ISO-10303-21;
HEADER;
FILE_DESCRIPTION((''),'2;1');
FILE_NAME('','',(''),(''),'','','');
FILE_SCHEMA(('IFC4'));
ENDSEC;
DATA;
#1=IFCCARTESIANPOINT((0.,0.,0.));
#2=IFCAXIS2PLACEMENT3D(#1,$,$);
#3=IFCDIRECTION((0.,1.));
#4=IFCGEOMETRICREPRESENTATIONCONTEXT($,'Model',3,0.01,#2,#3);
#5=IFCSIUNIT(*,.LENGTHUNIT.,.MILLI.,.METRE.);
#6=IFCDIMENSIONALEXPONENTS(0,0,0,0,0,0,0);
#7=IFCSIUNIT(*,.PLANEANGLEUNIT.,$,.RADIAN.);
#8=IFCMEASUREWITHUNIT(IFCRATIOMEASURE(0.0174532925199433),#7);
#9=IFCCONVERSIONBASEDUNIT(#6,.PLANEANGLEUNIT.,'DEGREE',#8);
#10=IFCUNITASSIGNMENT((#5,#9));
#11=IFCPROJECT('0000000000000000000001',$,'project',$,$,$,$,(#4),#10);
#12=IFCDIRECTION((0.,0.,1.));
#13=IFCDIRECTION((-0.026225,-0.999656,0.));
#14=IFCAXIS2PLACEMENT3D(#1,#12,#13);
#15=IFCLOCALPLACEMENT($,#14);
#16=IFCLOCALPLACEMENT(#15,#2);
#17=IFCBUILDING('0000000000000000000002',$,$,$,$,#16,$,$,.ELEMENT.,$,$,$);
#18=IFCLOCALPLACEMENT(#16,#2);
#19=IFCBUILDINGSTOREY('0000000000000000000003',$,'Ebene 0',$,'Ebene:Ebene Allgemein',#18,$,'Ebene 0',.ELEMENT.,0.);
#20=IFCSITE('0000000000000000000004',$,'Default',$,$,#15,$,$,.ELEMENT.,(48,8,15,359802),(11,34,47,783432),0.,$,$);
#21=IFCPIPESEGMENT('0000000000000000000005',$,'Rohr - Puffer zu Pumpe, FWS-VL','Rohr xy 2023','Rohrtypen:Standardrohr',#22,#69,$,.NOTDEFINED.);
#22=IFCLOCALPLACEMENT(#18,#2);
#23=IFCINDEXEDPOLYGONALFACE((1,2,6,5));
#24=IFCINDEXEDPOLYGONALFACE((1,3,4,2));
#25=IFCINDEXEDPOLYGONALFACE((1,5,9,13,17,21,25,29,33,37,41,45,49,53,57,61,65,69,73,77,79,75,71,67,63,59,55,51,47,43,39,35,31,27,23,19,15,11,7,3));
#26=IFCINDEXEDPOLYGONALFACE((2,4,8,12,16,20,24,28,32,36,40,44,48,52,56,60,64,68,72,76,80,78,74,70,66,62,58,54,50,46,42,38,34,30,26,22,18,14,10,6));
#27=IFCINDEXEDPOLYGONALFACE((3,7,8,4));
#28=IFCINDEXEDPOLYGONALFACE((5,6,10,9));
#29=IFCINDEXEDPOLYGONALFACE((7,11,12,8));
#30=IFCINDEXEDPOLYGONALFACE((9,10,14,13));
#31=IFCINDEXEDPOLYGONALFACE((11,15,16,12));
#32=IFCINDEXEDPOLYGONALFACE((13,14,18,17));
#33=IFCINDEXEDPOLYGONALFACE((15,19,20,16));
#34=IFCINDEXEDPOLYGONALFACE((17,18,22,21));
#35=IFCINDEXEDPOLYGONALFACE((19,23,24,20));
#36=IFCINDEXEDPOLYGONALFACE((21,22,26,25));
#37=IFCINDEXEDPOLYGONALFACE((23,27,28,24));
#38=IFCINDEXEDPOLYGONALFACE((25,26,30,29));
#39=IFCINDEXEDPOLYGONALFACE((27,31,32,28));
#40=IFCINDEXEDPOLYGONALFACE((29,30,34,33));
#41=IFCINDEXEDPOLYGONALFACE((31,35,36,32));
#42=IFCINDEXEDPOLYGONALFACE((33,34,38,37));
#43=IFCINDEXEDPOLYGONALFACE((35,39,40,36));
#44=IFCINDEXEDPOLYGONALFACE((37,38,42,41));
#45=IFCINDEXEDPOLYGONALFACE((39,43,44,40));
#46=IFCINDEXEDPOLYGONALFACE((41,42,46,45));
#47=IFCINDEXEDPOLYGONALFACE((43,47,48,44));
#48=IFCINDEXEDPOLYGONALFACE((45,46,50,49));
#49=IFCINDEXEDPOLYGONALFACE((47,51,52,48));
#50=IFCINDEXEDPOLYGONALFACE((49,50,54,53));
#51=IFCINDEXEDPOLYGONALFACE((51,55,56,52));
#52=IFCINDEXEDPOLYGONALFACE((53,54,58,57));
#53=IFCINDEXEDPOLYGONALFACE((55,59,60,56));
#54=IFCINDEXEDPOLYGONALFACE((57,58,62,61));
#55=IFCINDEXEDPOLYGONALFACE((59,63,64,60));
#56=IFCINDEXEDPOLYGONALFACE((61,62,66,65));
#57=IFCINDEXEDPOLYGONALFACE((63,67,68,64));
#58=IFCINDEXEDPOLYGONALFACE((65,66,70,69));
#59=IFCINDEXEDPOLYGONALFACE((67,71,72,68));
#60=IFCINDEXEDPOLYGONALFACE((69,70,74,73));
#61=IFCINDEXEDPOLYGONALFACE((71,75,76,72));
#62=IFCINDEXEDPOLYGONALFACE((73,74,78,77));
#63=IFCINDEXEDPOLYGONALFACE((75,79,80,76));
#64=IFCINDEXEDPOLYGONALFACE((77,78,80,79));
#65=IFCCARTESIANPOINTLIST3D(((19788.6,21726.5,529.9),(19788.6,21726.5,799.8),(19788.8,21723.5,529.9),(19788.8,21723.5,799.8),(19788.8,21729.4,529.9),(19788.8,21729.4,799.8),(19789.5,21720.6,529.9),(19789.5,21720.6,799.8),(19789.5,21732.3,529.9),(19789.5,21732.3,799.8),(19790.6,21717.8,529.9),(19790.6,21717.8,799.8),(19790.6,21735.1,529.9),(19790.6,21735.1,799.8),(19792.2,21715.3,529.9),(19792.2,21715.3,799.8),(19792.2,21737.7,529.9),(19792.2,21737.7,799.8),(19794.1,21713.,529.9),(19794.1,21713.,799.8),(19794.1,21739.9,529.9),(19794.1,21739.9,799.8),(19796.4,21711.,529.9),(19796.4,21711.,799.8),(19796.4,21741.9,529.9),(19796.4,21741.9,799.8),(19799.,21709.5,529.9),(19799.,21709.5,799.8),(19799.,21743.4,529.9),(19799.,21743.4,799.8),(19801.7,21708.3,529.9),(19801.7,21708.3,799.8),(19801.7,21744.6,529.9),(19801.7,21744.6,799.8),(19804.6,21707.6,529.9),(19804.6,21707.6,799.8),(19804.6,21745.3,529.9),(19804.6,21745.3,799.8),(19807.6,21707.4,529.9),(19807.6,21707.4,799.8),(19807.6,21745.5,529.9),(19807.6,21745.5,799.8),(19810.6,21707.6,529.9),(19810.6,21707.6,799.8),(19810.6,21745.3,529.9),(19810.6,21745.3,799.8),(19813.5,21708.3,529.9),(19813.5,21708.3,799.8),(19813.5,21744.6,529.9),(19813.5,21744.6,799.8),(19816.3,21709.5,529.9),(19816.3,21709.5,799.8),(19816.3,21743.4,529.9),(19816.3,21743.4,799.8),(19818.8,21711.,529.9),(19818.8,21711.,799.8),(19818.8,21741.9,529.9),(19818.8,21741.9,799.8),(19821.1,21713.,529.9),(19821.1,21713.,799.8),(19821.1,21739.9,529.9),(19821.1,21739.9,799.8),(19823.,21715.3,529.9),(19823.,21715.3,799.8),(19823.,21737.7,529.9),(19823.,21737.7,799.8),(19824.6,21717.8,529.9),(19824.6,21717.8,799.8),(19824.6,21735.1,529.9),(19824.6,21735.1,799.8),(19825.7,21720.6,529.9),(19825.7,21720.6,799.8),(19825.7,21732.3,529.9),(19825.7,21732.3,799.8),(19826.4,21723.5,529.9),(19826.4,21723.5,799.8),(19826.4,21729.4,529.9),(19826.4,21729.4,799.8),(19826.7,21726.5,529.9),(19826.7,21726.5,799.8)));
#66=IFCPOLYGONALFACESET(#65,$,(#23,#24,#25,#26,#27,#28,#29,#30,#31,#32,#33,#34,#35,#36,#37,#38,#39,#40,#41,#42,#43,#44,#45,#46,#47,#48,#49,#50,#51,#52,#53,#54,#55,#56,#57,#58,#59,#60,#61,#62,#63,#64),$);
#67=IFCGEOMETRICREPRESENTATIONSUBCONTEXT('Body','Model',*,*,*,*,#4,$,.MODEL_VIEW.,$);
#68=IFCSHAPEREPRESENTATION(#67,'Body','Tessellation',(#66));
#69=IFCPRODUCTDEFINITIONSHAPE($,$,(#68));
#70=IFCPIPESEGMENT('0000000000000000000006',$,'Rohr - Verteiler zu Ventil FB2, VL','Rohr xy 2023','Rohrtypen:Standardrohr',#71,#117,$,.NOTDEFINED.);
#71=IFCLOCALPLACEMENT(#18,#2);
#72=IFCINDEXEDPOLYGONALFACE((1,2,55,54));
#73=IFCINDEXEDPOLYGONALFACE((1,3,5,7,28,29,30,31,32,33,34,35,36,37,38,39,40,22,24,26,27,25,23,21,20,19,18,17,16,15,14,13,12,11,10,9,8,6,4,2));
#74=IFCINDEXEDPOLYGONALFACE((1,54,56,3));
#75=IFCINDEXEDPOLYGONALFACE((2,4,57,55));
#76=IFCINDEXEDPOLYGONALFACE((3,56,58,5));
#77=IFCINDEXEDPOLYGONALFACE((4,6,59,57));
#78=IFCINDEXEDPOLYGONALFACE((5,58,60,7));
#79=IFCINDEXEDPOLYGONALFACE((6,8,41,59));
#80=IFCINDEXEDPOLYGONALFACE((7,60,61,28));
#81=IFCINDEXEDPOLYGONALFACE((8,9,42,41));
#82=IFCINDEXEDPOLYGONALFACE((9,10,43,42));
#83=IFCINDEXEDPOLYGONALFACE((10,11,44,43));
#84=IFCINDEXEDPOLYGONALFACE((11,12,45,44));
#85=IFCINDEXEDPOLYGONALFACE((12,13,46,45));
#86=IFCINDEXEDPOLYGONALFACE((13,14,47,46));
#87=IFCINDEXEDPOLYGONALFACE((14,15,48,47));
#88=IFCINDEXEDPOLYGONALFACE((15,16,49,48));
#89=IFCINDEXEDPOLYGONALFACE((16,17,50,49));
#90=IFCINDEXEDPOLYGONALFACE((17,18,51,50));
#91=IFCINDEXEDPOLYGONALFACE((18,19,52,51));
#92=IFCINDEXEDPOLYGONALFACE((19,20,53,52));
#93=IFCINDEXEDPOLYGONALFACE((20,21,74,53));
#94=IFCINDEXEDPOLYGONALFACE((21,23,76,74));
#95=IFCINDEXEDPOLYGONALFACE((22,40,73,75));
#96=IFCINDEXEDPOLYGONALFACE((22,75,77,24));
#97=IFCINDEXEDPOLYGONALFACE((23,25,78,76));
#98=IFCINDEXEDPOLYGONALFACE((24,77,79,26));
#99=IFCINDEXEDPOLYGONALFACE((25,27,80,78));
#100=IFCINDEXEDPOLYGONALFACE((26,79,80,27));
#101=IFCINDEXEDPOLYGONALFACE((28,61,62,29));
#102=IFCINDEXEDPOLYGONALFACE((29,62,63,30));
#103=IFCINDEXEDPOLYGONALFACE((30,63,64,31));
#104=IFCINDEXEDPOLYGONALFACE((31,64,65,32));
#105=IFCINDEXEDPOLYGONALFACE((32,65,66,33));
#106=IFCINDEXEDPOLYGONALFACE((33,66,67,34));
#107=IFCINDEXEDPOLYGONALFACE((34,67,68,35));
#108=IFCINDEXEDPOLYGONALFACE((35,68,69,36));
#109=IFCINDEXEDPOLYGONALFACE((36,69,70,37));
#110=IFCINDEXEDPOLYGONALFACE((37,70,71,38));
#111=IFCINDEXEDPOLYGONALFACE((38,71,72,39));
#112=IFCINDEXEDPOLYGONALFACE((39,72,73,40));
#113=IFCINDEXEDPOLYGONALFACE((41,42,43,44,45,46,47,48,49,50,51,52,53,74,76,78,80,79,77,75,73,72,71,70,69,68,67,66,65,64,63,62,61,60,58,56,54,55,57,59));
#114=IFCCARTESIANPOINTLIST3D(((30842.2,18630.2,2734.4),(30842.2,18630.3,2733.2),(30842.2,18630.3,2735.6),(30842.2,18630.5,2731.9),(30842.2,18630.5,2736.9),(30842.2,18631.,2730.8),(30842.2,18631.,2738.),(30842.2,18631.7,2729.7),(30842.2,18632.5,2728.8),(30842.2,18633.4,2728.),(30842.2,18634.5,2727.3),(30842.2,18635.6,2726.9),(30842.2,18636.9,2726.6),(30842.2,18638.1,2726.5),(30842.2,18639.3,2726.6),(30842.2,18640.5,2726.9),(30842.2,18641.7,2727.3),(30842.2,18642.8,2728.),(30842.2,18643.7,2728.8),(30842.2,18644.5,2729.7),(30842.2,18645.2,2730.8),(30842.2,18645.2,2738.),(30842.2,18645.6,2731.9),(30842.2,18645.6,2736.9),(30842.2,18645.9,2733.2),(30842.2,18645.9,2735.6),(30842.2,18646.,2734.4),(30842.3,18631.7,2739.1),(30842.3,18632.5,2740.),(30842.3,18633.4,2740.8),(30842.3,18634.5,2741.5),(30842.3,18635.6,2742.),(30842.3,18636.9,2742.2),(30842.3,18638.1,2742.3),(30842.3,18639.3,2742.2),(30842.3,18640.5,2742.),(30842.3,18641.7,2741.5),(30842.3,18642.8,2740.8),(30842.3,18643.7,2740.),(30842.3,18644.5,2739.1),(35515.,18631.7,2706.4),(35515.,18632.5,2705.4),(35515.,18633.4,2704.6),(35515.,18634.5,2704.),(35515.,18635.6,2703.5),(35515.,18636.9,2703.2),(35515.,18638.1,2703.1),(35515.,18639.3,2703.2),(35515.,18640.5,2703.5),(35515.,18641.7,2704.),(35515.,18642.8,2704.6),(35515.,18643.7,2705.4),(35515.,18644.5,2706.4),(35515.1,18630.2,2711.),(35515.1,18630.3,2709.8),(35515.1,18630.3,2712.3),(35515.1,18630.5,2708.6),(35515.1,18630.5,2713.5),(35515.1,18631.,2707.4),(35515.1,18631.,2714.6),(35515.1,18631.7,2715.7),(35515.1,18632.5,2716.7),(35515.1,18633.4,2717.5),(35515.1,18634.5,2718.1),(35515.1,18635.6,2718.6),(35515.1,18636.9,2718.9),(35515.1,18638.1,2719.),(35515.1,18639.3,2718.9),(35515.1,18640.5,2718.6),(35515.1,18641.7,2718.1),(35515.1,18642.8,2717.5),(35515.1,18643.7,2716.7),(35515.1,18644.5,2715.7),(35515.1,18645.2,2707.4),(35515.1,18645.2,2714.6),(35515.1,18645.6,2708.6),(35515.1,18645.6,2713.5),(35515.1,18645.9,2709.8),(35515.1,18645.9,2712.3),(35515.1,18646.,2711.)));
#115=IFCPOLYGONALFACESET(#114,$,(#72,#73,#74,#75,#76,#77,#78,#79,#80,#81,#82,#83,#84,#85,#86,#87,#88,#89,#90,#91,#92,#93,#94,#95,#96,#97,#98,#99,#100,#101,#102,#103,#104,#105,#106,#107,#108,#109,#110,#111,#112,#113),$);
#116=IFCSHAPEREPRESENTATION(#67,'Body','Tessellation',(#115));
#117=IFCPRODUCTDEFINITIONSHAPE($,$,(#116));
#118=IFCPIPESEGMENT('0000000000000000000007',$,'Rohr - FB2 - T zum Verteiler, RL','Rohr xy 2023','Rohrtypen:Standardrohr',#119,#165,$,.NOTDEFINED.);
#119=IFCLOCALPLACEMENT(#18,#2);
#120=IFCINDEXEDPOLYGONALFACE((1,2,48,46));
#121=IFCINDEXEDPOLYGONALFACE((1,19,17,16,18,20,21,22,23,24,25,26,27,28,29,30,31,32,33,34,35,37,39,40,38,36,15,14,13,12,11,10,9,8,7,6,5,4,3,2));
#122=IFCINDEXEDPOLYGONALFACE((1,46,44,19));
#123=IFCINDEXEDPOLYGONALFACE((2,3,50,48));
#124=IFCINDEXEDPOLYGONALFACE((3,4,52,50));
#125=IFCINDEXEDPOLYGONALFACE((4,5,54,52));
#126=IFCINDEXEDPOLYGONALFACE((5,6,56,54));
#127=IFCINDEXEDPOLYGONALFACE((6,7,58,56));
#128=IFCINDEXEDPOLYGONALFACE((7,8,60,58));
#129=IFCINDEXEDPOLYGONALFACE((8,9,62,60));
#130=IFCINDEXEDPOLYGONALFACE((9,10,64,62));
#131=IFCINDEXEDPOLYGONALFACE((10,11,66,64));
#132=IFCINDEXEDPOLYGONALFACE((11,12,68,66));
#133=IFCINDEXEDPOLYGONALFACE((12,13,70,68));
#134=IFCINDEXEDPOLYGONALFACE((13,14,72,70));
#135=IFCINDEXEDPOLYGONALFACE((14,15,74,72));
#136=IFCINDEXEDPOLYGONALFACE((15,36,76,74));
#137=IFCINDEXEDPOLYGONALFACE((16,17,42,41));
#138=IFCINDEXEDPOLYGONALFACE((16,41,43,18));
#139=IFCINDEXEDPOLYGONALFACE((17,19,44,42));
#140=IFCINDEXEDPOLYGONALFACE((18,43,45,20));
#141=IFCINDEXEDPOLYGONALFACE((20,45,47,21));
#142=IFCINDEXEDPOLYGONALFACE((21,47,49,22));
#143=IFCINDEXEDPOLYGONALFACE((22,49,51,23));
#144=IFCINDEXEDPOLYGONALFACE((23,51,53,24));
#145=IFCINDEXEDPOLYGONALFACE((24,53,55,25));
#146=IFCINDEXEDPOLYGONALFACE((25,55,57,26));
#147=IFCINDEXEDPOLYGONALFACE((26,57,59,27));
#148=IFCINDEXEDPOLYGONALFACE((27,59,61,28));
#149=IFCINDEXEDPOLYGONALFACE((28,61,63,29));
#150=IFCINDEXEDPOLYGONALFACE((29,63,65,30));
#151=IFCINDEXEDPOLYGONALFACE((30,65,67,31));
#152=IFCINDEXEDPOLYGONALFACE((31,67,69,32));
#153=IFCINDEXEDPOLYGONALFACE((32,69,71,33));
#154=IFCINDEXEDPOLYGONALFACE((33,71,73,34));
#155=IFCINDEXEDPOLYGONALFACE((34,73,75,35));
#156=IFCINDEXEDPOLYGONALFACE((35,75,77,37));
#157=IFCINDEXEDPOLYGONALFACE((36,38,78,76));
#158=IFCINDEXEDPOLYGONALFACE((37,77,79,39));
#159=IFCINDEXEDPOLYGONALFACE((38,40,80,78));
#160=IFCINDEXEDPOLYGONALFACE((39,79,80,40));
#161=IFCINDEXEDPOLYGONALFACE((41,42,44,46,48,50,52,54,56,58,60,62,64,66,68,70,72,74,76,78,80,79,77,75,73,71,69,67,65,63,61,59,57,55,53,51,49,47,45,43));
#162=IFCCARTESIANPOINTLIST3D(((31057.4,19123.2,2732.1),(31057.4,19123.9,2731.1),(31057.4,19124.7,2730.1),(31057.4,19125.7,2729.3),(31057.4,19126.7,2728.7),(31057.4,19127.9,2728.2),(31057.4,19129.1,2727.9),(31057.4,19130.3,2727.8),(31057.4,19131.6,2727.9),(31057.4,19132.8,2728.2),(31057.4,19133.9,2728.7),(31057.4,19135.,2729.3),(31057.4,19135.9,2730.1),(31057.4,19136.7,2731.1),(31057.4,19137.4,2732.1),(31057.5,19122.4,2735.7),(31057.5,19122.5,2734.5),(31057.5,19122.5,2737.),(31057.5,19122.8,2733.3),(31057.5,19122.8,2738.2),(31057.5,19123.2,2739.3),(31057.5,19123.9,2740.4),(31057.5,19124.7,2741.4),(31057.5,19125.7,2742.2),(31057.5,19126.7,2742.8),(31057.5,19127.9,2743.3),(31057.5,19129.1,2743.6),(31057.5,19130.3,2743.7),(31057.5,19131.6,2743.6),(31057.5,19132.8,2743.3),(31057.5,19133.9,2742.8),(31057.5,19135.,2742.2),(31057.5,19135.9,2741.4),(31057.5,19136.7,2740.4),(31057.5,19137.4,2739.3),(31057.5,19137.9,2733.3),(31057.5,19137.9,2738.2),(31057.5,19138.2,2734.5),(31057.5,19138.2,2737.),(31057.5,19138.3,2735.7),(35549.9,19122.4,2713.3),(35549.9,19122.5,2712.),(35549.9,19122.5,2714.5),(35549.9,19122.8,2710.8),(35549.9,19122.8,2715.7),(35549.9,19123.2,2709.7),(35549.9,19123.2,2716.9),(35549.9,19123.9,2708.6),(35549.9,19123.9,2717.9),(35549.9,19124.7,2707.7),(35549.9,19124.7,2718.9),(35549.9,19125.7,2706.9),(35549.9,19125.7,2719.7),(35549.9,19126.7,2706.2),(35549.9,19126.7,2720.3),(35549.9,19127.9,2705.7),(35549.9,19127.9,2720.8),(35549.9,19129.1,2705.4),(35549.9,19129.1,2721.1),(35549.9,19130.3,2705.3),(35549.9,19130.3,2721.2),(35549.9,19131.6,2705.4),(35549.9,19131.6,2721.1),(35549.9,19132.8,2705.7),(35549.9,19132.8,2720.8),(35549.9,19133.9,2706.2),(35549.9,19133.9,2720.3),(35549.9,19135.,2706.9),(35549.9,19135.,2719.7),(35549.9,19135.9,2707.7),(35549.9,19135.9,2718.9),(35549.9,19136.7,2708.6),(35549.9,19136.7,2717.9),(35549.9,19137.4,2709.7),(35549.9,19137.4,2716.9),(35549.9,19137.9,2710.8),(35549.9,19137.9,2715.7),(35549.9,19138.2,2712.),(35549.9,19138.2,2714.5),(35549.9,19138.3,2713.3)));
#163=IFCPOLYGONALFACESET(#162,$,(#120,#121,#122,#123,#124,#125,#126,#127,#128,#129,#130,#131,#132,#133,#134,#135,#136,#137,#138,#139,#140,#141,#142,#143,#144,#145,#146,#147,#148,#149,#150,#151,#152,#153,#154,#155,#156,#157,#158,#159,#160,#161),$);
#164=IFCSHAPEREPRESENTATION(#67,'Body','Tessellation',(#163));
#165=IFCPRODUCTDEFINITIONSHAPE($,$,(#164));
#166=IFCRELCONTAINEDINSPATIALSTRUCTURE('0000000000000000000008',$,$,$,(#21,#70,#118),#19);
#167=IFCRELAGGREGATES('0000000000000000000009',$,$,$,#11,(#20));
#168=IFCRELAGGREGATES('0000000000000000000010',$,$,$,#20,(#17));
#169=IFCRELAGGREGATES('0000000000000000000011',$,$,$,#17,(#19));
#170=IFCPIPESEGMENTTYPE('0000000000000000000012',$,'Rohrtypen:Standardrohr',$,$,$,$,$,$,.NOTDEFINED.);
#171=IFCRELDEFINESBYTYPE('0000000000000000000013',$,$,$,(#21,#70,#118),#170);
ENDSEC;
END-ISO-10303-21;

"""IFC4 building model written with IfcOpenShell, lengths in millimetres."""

from ifc_helpers import new_model, entity, si_unit, converted_unit, direction, frame, origin, place, context, subcontext, project, spatial, indexed_curve, outline, extrude, type_object, element, save


model = new_model("IFC4")

# Units and contexts
model_context = context("Model", 3, precision=0.01, world=origin(), true_north=direction((0.0, 1.0)))
body_context = subcontext(model_context, "Body", "Model", "MODEL_VIEW")
ifc_project = project(units=[si_unit("LENGTHUNIT", "METRE", prefix="MILLI"), converted_unit("PLANEANGLEUNIT", "DEGREE", entity("IfcRatioMeasure", 0.0174532925199433), si_unit("PLANEANGLEUNIT", "RADIAN"), dimensions=[0, 0, 0, 0, 0, 0, 0])], contexts=[model_context])

# Site, building, storey
site_placement = place(None, frame((0.0, 0.0, 0.0), z_axis=(0.0, 0.0, 1.0), x_axis=(-0.026225, -0.999656, 0.0)))
site = spatial("IfcSite", under=ifc_project, at=site_placement, Name="Default", CompositionType="ELEMENT", RefLatitude=(48, 8, 15, 359802), RefLongitude=(11, 34, 47, 783432), RefElevation=0.0)
building_placement = place(site_placement, origin())
building = spatial("IfcBuilding", under=site, at=building_placement, CompositionType="ELEMENT")
storey_placement = place(building_placement, origin())
storey = spatial("IfcBuildingStorey", under=building, at=storey_placement, Name="Ebene 0", ObjectType="Ebene:Ebene Allgemein", LongName="Ebene 0", CompositionType="ELEMENT", Elevation=0.0)

# Pipe segments
pipe_segment_type = type_object("IfcPipeSegmentType", Name="Rohrtypen:Standardrohr", PredefinedType="NOTDEFINED")
pipe_segment_1_placement = place(storey_placement, origin())
element("IfcPipeSegment", 1, at=pipe_segment_1_placement, inside=storey, type_object=pipe_segment_type, Name="Rohr - Puffer zu Pumpe, FWS-VL", Description="Rohr xy 2023", ObjectType="Rohrtypen:Standardrohr", PredefinedType="NOTDEFINED", context=body_context, shape_type="SweptSolid", body=[
    extrude(outline(indexed_curve([(19.1, 0.0), (18.8, 3.0), (18.1, 5.9), (17.0, 8.6), (15.4, 11.2), (13.5, 13.5), (11.2, 15.4), (8.6, 17.0), (5.9, 18.1), (3.0, 18.8), (0.0, 19.0), (-3.0, 18.8), (-5.9, 18.1), (-8.6, 17.0), (-11.2, 15.4), (-13.5, 13.5), (-15.4, 11.2), (-17.0, 8.6), (-18.1, 5.9), (-18.8, 3.0), (-19.1, 0.0), (-18.8, -3.0), (-18.1, -5.9), (-17.0, -8.6), (-15.4, -11.2), (-13.5, -13.5), (-11.2, -15.4), (-8.6, -17.0), (-5.9, -18.1), (-3.0, -18.8), (0.0, -19.0), (3.0, -18.8), (5.9, -18.1), (8.6, -17.0), (11.2, -15.4), (13.5, -13.5), (15.4, -11.2), (17.0, -8.6), (18.1, -5.9), (18.8, -3.0), (19.1, 0.0)], self_intersect=False)), frame((19807.6, 21726.5, 529.9), z_axis=(0.000002, 0.000002, 1.0), x_axis=(-1.0, 0.0, 0.000002)), (0.0, 0.0, 1.0), 269.9),
])
pipe_segment_2_placement = place(storey_placement, origin())
element("IfcPipeSegment", 2, at=pipe_segment_2_placement, inside=storey, type_object=pipe_segment_type, Name="Rohr - Verteiler zu Ventil FB2, VL", Description="Rohr xy 2023", ObjectType="Rohrtypen:Standardrohr", PredefinedType="NOTDEFINED", context=body_context, shape_type="SweptSolid", body=[
    extrude(outline(indexed_curve([(7.9, 0.0), (7.8, 1.2), (7.6, 2.5), (7.1, 3.6), (6.4, 4.7), (5.6, 5.6), (4.7, 6.4), (3.6, 7.1), (2.5, 7.6), (1.2, 7.8), (0.0, 7.9), (-1.2, 7.8), (-2.5, 7.6), (-3.6, 7.1), (-4.7, 6.4), (-5.6, 5.6), (-6.4, 4.7), (-7.1, 3.6), (-7.6, 2.5), (-7.8, 1.2), (-7.9, 0.0), (-7.8, -1.2), (-7.6, -2.5), (-7.1, -3.6), (-6.4, -4.7), (-5.6, -5.6), (-4.7, -6.4), (-3.6, -7.1), (-2.5, -7.6), (-1.2, -7.8), (0.0, -7.9), (1.2, -7.8), (2.5, -7.6), (3.6, -7.1), (4.7, -6.4), (5.6, -5.6), (6.4, -4.7), (7.1, -3.6), (7.6, -2.5), (7.8, -1.2), (7.9, 0.0)], self_intersect=False)), frame((35515.1, 18638.1, 2711.0), z_axis=(-0.999988, 0.0, 0.005), x_axis=(0.0, 1.0, 0.0)), (0.0, 0.0, 1.0), 4672.9),
])
pipe_segment_3_placement = place(storey_placement, origin())
element("IfcPipeSegment", 3, at=pipe_segment_3_placement, inside=storey, type_object=pipe_segment_type, Name="Rohr - FB2 - T zum Verteiler, RL", Description="Rohr xy 2023", ObjectType="Rohrtypen:Standardrohr", PredefinedType="NOTDEFINED", context=body_context, shape_type="SweptSolid", body=[
    extrude(outline(indexed_curve([(7.9, 0.0), (7.8, 1.2), (7.6, 2.5), (7.1, 3.6), (6.4, 4.7), (5.6, 5.6), (4.7, 6.4), (3.6, 7.1), (2.5, 7.6), (1.2, 7.8), (0.0, 7.9), (-1.2, 7.8), (-2.5, 7.6), (-3.6, 7.1), (-4.7, 6.4), (-5.6, 5.6), (-6.4, 4.7), (-7.1, 3.6), (-7.6, 2.5), (-7.8, 1.2), (-7.9, 0.0), (-7.8, -1.2), (-7.6, -2.5), (-7.1, -3.6), (-6.4, -4.7), (-5.6, -5.6), (-4.7, -6.4), (-3.6, -7.1), (-2.5, -7.6), (-1.2, -7.8), (0.0, -7.9), (1.2, -7.8), (2.5, -7.6), (3.6, -7.1), (4.7, -6.4), (5.6, -5.6), (6.4, -4.7), (7.1, -3.6), (7.6, -2.5), (7.8, -1.2), (7.9, 0.0)], self_intersect=False)), frame((35549.9, 19130.3, 2713.3), z_axis=(-0.999988, 0.0, 0.005), x_axis=(0.0, 1.0, 0.0)), (0.0, 0.0, 1.0), 4492.5),
])

save(model, "model.ifc")
